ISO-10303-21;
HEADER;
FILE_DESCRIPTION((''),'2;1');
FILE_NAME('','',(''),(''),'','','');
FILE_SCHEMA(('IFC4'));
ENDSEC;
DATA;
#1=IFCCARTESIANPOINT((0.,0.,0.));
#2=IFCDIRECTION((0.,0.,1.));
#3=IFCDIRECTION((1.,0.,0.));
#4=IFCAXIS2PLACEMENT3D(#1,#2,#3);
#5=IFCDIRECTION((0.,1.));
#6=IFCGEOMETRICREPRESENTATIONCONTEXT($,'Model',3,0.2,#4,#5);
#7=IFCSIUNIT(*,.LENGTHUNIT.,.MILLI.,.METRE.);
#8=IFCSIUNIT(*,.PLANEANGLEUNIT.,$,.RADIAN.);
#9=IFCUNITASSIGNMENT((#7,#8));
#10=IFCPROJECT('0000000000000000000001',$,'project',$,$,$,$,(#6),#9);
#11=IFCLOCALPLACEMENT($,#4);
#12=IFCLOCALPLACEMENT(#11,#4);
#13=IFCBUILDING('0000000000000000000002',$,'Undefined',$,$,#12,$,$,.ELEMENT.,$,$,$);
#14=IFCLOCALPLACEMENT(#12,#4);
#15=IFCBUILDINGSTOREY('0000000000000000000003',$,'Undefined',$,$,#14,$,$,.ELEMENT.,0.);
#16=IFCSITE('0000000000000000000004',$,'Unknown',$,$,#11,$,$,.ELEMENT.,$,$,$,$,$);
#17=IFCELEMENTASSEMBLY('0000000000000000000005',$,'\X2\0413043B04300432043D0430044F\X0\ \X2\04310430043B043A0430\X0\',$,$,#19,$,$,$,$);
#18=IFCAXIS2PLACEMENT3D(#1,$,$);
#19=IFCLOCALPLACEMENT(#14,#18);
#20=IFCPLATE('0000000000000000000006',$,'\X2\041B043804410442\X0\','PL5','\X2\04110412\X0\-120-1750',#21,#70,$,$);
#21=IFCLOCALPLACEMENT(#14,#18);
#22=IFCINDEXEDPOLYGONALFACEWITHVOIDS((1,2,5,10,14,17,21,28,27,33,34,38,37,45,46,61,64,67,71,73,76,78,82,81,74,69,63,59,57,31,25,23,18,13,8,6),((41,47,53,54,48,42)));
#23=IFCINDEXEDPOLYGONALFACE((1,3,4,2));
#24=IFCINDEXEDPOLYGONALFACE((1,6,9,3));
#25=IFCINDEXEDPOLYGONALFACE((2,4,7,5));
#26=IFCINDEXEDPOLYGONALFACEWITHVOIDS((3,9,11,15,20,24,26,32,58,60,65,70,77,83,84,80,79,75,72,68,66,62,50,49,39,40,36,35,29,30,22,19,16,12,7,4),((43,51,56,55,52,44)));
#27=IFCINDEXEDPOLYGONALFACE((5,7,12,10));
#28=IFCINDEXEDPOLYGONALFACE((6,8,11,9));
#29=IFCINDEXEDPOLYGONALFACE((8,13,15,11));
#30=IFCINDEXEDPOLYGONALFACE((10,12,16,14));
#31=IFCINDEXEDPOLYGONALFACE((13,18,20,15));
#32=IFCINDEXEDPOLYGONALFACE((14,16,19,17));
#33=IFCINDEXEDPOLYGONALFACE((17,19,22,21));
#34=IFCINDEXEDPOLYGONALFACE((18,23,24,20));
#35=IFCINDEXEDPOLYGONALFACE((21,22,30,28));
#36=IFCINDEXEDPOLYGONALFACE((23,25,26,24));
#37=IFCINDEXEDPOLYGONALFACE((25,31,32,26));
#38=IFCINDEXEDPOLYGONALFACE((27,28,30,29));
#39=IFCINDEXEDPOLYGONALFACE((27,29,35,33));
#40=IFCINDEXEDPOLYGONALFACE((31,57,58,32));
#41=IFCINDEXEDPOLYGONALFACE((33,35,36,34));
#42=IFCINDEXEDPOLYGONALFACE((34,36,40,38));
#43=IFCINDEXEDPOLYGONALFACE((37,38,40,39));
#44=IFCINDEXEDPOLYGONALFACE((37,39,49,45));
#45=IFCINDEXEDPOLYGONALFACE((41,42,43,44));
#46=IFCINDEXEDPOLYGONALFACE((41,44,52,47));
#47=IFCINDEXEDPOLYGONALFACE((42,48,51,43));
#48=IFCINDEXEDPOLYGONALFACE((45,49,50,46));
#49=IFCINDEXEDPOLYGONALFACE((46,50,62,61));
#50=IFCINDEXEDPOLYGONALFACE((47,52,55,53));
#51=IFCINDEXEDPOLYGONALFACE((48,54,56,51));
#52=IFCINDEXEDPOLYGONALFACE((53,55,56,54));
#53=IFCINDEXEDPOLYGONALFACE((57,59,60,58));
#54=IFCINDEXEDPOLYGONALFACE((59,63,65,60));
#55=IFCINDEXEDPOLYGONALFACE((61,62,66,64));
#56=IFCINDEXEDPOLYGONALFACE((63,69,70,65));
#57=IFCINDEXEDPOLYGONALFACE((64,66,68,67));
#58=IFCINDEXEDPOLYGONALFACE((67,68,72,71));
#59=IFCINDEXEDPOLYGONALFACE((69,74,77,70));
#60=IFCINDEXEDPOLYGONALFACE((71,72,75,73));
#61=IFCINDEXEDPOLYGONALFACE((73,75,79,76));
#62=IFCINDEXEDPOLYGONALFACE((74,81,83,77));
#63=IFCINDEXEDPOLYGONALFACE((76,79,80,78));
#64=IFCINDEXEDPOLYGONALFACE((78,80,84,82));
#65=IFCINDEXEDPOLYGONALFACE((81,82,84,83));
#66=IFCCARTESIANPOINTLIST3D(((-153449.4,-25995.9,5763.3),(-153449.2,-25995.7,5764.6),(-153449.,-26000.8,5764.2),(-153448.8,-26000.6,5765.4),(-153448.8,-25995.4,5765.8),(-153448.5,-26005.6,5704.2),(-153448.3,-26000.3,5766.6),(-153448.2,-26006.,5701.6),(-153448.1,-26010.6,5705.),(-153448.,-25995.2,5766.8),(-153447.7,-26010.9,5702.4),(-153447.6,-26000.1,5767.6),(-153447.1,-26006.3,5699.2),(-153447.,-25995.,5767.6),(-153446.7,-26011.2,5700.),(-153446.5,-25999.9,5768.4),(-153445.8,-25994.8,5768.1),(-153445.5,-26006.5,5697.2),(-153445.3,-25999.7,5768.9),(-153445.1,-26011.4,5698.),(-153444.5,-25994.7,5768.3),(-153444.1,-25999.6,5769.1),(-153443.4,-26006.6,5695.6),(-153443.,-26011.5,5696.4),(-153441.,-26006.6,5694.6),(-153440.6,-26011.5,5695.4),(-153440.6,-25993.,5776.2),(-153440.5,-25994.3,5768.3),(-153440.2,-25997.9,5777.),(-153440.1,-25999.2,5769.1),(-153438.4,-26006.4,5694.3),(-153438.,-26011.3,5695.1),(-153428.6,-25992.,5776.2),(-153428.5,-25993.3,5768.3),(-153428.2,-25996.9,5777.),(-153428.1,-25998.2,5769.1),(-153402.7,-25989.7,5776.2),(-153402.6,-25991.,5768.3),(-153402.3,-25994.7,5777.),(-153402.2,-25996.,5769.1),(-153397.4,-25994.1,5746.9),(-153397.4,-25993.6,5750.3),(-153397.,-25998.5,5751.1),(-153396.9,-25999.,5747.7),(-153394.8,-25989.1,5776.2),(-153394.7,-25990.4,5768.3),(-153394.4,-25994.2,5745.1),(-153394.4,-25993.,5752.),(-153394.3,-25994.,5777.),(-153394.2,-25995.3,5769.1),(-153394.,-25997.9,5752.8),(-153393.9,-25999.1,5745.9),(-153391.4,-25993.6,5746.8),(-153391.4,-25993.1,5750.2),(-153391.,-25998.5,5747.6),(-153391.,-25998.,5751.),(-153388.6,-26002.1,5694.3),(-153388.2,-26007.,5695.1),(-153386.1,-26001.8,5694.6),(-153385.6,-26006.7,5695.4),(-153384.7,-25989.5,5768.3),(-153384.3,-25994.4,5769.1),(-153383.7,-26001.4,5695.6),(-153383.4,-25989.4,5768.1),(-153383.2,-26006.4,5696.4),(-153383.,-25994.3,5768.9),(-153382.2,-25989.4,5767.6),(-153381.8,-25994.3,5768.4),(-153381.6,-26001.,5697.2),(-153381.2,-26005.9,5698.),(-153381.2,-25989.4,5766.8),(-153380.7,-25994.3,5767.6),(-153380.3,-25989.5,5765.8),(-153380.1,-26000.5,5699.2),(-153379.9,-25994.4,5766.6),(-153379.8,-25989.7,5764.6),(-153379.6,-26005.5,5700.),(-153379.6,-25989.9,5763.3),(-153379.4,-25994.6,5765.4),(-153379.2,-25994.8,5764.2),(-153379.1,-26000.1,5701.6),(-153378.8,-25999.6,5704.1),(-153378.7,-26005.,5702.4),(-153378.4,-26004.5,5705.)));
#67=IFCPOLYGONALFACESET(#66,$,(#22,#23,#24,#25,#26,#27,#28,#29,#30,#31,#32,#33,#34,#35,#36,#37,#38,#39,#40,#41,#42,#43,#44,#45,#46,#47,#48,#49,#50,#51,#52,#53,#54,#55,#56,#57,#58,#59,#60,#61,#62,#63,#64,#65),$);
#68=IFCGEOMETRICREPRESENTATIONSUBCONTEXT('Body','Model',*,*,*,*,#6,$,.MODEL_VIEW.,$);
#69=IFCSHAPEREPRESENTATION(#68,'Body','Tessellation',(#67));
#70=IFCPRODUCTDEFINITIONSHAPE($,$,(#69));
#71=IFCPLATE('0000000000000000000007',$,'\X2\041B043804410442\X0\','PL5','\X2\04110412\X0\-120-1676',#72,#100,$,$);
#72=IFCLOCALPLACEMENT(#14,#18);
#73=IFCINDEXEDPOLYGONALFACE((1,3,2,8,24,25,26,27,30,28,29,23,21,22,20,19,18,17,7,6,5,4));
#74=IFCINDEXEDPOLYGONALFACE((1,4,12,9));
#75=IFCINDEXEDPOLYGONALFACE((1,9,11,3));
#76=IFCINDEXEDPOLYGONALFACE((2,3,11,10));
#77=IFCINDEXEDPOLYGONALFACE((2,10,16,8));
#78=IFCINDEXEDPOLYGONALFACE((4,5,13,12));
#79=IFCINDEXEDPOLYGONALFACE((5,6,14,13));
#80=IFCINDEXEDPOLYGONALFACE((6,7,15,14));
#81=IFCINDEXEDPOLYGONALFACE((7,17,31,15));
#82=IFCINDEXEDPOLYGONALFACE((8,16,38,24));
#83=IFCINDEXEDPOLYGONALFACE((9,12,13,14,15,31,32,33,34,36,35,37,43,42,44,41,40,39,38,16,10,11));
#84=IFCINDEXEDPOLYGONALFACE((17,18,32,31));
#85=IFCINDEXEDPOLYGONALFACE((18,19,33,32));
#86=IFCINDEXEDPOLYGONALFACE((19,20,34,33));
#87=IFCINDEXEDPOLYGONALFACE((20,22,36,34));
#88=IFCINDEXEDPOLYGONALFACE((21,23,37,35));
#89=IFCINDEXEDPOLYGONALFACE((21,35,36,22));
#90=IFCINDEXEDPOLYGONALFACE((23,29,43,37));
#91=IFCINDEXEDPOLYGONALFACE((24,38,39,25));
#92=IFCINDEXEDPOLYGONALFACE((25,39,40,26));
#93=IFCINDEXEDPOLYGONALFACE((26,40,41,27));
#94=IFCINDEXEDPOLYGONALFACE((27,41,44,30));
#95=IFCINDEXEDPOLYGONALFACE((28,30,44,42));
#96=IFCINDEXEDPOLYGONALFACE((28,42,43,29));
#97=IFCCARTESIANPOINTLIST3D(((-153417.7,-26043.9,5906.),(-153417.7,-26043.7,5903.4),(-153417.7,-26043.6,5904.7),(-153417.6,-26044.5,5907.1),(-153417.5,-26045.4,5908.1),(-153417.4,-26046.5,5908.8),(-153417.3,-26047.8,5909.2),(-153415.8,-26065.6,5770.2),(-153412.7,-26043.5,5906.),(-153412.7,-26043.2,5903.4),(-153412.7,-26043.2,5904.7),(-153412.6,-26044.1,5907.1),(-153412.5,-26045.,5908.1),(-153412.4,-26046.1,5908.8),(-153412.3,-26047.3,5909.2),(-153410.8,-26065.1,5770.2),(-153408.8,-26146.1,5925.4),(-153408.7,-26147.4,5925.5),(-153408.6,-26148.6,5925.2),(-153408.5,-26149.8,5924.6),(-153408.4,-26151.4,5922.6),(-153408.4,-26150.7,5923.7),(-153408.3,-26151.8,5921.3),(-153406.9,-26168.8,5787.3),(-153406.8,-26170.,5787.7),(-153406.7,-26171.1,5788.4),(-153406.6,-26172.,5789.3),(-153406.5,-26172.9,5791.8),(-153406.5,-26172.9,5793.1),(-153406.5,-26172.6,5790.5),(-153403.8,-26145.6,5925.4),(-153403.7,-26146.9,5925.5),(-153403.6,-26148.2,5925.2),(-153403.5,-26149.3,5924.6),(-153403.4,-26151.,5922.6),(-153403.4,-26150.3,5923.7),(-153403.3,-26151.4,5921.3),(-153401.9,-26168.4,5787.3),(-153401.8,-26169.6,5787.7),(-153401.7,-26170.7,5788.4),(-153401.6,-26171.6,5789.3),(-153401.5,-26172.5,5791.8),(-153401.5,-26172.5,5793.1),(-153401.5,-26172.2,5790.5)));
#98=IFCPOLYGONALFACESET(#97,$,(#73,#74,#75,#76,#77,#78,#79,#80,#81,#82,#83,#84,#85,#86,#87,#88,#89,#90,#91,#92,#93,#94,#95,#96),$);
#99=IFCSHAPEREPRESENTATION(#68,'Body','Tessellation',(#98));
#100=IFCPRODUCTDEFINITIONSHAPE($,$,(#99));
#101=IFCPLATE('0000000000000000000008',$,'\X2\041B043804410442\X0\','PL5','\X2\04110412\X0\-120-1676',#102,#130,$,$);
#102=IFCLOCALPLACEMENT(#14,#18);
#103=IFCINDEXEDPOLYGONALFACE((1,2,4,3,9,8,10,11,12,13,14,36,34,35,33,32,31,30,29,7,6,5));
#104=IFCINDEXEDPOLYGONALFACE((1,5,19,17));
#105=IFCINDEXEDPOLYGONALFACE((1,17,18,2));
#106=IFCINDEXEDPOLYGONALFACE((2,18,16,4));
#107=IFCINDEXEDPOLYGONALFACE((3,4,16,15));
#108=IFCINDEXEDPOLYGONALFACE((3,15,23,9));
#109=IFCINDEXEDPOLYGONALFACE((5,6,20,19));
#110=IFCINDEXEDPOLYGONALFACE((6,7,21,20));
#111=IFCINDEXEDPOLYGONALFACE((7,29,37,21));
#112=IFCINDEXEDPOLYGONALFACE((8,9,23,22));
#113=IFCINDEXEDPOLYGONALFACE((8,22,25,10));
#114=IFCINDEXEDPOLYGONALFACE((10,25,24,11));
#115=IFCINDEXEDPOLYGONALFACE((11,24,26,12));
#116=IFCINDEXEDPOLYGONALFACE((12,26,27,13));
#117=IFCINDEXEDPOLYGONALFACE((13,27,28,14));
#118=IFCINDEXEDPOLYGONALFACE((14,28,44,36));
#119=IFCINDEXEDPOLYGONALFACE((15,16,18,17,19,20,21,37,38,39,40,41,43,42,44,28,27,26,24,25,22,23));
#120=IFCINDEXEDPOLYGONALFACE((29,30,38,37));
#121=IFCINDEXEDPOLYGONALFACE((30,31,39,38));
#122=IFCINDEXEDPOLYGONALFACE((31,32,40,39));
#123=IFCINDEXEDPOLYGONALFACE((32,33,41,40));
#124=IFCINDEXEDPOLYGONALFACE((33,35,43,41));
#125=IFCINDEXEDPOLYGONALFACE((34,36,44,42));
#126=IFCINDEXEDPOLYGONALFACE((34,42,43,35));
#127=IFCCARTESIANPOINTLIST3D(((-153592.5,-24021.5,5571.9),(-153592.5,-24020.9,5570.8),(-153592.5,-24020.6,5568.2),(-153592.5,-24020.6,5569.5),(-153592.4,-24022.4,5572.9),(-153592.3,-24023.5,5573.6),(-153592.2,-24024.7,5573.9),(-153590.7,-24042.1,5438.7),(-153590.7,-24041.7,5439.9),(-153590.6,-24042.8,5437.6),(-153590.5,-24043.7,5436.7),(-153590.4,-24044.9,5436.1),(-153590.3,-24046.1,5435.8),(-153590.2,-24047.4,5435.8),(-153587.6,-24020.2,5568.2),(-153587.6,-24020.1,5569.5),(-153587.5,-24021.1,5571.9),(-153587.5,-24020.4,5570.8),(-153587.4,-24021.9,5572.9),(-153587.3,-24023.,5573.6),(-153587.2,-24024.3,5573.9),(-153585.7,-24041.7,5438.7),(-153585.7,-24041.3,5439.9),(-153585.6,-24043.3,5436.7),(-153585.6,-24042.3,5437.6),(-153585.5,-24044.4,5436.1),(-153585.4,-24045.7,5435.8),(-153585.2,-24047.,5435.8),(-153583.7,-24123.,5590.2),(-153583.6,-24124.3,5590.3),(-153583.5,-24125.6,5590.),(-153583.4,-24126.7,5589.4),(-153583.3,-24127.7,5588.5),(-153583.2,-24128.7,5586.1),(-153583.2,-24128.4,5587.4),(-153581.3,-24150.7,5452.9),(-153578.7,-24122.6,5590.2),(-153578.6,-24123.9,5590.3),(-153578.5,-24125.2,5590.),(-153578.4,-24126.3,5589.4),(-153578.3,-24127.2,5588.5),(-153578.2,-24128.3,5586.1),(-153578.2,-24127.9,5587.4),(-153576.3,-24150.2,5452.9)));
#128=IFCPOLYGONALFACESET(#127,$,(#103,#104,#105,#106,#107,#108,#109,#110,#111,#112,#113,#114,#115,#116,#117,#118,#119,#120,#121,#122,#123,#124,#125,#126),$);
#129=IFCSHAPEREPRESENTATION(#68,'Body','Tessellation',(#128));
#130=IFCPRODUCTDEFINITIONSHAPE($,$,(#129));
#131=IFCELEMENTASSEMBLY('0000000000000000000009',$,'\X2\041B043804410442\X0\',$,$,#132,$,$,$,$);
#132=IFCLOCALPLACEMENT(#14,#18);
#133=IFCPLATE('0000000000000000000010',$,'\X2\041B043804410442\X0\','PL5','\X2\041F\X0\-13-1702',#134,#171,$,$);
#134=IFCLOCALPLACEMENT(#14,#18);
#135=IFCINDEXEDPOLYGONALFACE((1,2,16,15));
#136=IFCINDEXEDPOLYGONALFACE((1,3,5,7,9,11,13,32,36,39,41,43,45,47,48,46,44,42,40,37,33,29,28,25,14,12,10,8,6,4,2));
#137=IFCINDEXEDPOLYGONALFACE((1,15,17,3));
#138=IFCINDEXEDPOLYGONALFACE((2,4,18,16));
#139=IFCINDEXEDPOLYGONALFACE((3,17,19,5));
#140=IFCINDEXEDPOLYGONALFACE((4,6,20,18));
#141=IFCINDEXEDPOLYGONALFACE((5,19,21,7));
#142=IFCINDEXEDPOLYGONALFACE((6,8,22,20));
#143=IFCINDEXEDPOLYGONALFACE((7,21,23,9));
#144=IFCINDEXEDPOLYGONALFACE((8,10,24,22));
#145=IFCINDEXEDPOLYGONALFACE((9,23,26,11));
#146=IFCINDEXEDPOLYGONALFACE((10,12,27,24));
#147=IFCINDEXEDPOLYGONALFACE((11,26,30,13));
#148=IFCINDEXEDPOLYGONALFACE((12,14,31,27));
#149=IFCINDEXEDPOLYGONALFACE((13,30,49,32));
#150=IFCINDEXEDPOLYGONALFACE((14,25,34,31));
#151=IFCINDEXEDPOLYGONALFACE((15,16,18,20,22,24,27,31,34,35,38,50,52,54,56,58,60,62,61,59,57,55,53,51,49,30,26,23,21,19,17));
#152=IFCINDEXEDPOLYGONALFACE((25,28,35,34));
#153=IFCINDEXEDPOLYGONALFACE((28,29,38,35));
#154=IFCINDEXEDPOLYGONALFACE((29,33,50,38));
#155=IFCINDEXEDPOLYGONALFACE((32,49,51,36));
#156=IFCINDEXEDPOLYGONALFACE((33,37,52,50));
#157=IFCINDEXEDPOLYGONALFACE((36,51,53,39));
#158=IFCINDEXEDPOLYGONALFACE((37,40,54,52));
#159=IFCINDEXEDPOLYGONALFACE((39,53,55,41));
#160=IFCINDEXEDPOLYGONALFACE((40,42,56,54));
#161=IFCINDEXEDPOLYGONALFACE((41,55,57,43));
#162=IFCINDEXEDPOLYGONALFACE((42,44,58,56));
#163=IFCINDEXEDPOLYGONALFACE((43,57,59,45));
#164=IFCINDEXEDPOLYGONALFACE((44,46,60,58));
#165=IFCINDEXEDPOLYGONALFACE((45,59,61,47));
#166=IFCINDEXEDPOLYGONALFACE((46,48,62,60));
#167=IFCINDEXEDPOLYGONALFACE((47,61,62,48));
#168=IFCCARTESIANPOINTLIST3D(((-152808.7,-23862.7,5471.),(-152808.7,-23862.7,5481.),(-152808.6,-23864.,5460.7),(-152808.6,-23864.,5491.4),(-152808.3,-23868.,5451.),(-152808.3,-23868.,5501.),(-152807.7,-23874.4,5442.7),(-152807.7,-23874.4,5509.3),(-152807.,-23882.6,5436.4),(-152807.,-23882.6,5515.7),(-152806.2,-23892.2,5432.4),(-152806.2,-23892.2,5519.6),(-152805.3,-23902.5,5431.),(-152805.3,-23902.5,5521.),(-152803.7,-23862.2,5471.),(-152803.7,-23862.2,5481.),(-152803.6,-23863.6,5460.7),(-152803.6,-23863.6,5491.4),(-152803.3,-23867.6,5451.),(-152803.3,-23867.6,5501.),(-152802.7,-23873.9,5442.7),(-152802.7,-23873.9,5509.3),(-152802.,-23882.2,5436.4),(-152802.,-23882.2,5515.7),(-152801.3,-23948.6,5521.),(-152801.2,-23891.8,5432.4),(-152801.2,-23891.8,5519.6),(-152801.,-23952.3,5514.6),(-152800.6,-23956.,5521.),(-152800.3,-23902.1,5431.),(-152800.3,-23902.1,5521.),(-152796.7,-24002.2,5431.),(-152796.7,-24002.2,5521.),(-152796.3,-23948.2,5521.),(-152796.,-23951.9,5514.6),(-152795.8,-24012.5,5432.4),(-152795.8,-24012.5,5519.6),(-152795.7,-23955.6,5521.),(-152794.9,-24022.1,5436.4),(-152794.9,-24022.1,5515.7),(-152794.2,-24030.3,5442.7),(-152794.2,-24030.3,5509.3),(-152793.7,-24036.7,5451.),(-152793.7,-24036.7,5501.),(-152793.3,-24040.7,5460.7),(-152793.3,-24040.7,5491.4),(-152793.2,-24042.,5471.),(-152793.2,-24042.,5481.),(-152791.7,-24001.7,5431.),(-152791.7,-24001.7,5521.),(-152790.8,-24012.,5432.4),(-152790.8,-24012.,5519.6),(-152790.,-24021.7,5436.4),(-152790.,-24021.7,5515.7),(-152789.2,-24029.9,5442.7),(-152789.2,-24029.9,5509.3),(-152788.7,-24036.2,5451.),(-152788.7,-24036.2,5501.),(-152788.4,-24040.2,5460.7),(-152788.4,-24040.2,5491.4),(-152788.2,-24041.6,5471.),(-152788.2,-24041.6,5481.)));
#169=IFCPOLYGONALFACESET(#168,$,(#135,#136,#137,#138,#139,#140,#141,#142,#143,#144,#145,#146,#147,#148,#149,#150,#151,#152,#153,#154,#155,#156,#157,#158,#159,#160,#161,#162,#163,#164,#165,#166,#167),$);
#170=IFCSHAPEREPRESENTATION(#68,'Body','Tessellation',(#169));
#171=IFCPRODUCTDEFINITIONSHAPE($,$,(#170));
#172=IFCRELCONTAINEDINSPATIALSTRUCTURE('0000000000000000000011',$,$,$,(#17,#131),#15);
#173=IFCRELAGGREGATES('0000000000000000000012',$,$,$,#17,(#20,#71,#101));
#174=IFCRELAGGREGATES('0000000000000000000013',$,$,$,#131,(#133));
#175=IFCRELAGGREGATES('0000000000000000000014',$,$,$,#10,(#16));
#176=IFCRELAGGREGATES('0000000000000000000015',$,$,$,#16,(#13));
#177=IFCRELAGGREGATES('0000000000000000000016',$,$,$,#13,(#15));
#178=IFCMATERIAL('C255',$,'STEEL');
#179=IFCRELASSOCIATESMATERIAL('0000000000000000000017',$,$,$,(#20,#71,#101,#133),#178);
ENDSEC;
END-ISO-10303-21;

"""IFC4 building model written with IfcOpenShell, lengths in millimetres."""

from ifc_helpers import new_model, si_unit, direction, frame, origin_with_axes, place, context, subcontext, project, spatial, line, arc, indexed_curve, outline, extrude, material, element, aggregate, save


model = new_model("IFC4")

# Units and contexts
model_context = context("Model", 3, precision=0.2, world=origin_with_axes(), true_north=direction((0.0, 1.0)))
body_context = subcontext(model_context, "Body", "Model", "MODEL_VIEW")
ifc_project = project(units=[si_unit("LENGTHUNIT", "METRE", prefix="MILLI"), si_unit("PLANEANGLEUNIT", "RADIAN")], contexts=[model_context])

# Site, building, storey
site_placement = place(None, origin_with_axes())
site = spatial("IfcSite", under=ifc_project, at=site_placement, Name="Unknown", CompositionType="ELEMENT")
building_placement = place(site_placement, origin_with_axes())
building = spatial("IfcBuilding", under=site, at=building_placement, Name="Undefined", CompositionType="ELEMENT")
storey_placement = place(building_placement, origin_with_axes())
storey = spatial("IfcBuildingStorey", under=building, at=storey_placement, Name="Undefined", CompositionType="ELEMENT", Elevation=0.0)

# Shared definitions
ifc_material_1 = material(Name="C255", Category="STEEL")

# Element assembly, plates, voiding feature
assembly_1_placement = place(storey_placement, frame((-153597.6, -23933.2, 5487.9), z_axis=(-0.996285, -0.086114, 0.000024), x_axis=(0.084961, -0.982981, 0.162881)))
assembly_1 = element("IfcElementAssembly", 1, at=assembly_1_placement, inside=storey, Name="Главная балка")
plate_1_placement = place(assembly_1_placement, frame((2087.5, -135.0, -40.0), z_axis=(-1.0, -0.000054, 0.0), x_axis=(0.0, 0.000054, 1.0)))
plate_1 = element("IfcPlate", 2, at=plate_1_placement, material=ifc_material_1, Name="Лист", Description="PL5", ObjectType="БВ-120-1750", context=body_context, shape_type="SolidModel", body=[
    extrude(outline(indexed_curve([(0.0, 10.0), (2.9, 2.9), (10.0, 0.0), (60.0, 0.0), (67.1, 2.9), (70.0, 10.0), (70.0, 70.0), (68.5, 73.5), (65.0, 75.0), (61.0, 75.0), (61.0, 83.0), (49.0, 83.0), (49.0, 75.0), (23.0, 75.0), (23.0, 83.0), (15.0, 83.0), (15.0, 75.0), (5.0, 75.0), (1.5, 73.5), (0.0, 70.0)], segments=[arc(1, 2, 3), line(3, 4), arc(4, 5, 6), line(6, 7), arc(7, 8, 9), line(9, 10, 11, 12, 13, 14, 15, 16, 17, 18), arc(18, 19, 20), line(20, 1)])), frame((0.0, 0.0, 2.5), z_axis=(0.0, 0.0, 1.0), x_axis=(1.0, 0.0, 0.0)), (0.0, 0.0, -1.0), 5.0),
])
voiding_feature_1_placement = place(plate_1_placement, frame((15.0, 55.0, 10.0), z_axis=(0.007997, -0.999968, -0.000026), x_axis=(0.0, 0.000026, -1.0)))
element("IfcVoidingFeature", 3, at=voiding_feature_1_placement, cuts=plate_1, Name="Балка", ObjectType="(?)", PredefinedType="HOLE", context=body_context, shape_type="SolidModel", body=[
    extrude(outline(indexed_curve([(1.7, -3.0), (3.5, 0.0), (1.7, 3.0), (-1.7, 3.0), (-3.5, 0.0), (-1.7, -3.0)], segments=[line(1, 2, 3, 4, 5, 6, 1)])), frame((0.0, 0.0, 0.0), z_axis=(-1.0, 0.0, 0.0), x_axis=(0.0, 0.0, 1.0)), (0.0, 0.0, -1.0), 20.0),
])
plate_2_placement = place(assembly_1_placement, frame((2267.5, 70.0, 0.0), z_axis=(0.0, 0.0, -1.0), x_axis=(0.0, -1.0, 0.0)))
plate_2 = element("IfcPlate", 4, at=plate_2_placement, material=ifc_material_1, Name="Лист", Description="PL5", ObjectType="БВ-120-1676", context=body_context, shape_type="SolidModel", body=[
    extrude(outline(indexed_curve([(0.0, 5.0), (1.5, 1.5), (5.0, 0.0), (135.0, 0.0), (138.5, 1.5), (140.0, 5.0), (140.0, 110.0), (5.0, 110.0), (1.5, 108.5), (0.0, 105.0)], segments=[arc(1, 2, 3), line(3, 4), arc(4, 5, 6), line(6, 7, 8), arc(8, 9, 10), line(10, 1)])), frame((0.0, 0.0, 2.5), z_axis=(0.0, 0.0, 1.0), x_axis=(1.0, 0.0, 0.0)), (0.0, 0.0, -1.0), 5.0),
])
plate_3_placement = place(assembly_1_placement, frame((99.4, 70.0, 0.0), z_axis=(0.0, 0.0, 1.0), x_axis=(0.0, -1.0, 0.0)))
plate_3 = element("IfcPlate", 5, at=plate_3_placement, material=ifc_material_1, Name="Лист", Description="PL5", ObjectType="БВ-120-1676", context=body_context, shape_type="SolidModel", body=[
    extrude(outline(indexed_curve([(0.0, 5.0), (1.5, 1.5), (5.0, 0.0), (135.0, 0.0), (138.5, 1.5), (140.0, 5.0), (140.0, 110.0), (5.0, 110.0), (1.5, 108.5), (0.0, 105.0)], segments=[arc(1, 2, 3), line(3, 4), arc(4, 5, 6), line(6, 7, 8), arc(8, 9, 10), line(10, 1)])), frame((0.0, 0.0, 2.5), z_axis=(0.0, 0.0, 1.0), x_axis=(1.0, 0.0, 0.0)), (0.0, 0.0, -1.0), 5.0),
])
aggregate(assembly_1, [plate_1, plate_2, plate_3])

# Element assembly, plate, voiding feature
assembly_2_placement = place(storey_placement, frame((-152790.7, -24041.8, 5431.0), z_axis=(-0.996285, -0.086114, 0.0), x_axis=(0.0, 0.0, 1.0)))
assembly_2 = element("IfcElementAssembly", 6, at=assembly_2_placement, inside=storey, Name="Лист")
plate_4_placement = place(assembly_2_placement, origin_with_axes())
plate_4 = element("IfcPlate", 7, at=plate_4_placement, material=ifc_material_1, Name="Лист", Description="PL5", ObjectType="П-13-1702", context=body_context, shape_type="SolidModel", body=[
    extrude(outline(indexed_curve([(0.0, 40.0), (11.7, 11.7), (40.0, 0.0), (50.0, 0.0), (78.3, 11.7), (90.0, 40.0), (90.0, 140.0), (78.3, 168.3), (50.0, 180.0), (40.0, 180.0), (11.7, 168.3), (0.0, 140.0)], segments=[arc(1, 2, 3), line(3, 4), arc(4, 5, 6), line(6, 7), arc(7, 8, 9), line(9, 10), arc(10, 11, 12), line(12, 1)])), frame((0.0, 0.0, 2.5), z_axis=(0.0, 0.0, 1.0), x_axis=(1.0, 0.0, 0.0)), (0.0, 0.0, -1.0), 5.0),
])
voiding_feature_2_placement = place(plate_4_placement, frame((90.5, 90.0, -3.5), z_axis=(-1.0, -0.000054, 0.0), x_axis=(0.0, 0.0, 1.0)))
element("IfcVoidingFeature", 8, at=voiding_feature_2_placement, cuts=plate_4, Name="Связь вертикальная", ObjectType="(?)", PredefinedType="HOLE", context=body_context, shape_type="SolidModel", body=[
    extrude(outline(indexed_curve([(0.0, -4.0), (6.9, 0.0), (0.0, 4.0)], segments=[line(1, 2, 3, 1)])), frame((0.0, 0.0, 0.0), z_axis=(-1.0, 0.0, 0.0), x_axis=(0.0, 0.0, 1.0)), (0.0, 0.0, -1.0), 7.0),
])
aggregate(assembly_2, [plate_4])

save(model, "model.ifc")
